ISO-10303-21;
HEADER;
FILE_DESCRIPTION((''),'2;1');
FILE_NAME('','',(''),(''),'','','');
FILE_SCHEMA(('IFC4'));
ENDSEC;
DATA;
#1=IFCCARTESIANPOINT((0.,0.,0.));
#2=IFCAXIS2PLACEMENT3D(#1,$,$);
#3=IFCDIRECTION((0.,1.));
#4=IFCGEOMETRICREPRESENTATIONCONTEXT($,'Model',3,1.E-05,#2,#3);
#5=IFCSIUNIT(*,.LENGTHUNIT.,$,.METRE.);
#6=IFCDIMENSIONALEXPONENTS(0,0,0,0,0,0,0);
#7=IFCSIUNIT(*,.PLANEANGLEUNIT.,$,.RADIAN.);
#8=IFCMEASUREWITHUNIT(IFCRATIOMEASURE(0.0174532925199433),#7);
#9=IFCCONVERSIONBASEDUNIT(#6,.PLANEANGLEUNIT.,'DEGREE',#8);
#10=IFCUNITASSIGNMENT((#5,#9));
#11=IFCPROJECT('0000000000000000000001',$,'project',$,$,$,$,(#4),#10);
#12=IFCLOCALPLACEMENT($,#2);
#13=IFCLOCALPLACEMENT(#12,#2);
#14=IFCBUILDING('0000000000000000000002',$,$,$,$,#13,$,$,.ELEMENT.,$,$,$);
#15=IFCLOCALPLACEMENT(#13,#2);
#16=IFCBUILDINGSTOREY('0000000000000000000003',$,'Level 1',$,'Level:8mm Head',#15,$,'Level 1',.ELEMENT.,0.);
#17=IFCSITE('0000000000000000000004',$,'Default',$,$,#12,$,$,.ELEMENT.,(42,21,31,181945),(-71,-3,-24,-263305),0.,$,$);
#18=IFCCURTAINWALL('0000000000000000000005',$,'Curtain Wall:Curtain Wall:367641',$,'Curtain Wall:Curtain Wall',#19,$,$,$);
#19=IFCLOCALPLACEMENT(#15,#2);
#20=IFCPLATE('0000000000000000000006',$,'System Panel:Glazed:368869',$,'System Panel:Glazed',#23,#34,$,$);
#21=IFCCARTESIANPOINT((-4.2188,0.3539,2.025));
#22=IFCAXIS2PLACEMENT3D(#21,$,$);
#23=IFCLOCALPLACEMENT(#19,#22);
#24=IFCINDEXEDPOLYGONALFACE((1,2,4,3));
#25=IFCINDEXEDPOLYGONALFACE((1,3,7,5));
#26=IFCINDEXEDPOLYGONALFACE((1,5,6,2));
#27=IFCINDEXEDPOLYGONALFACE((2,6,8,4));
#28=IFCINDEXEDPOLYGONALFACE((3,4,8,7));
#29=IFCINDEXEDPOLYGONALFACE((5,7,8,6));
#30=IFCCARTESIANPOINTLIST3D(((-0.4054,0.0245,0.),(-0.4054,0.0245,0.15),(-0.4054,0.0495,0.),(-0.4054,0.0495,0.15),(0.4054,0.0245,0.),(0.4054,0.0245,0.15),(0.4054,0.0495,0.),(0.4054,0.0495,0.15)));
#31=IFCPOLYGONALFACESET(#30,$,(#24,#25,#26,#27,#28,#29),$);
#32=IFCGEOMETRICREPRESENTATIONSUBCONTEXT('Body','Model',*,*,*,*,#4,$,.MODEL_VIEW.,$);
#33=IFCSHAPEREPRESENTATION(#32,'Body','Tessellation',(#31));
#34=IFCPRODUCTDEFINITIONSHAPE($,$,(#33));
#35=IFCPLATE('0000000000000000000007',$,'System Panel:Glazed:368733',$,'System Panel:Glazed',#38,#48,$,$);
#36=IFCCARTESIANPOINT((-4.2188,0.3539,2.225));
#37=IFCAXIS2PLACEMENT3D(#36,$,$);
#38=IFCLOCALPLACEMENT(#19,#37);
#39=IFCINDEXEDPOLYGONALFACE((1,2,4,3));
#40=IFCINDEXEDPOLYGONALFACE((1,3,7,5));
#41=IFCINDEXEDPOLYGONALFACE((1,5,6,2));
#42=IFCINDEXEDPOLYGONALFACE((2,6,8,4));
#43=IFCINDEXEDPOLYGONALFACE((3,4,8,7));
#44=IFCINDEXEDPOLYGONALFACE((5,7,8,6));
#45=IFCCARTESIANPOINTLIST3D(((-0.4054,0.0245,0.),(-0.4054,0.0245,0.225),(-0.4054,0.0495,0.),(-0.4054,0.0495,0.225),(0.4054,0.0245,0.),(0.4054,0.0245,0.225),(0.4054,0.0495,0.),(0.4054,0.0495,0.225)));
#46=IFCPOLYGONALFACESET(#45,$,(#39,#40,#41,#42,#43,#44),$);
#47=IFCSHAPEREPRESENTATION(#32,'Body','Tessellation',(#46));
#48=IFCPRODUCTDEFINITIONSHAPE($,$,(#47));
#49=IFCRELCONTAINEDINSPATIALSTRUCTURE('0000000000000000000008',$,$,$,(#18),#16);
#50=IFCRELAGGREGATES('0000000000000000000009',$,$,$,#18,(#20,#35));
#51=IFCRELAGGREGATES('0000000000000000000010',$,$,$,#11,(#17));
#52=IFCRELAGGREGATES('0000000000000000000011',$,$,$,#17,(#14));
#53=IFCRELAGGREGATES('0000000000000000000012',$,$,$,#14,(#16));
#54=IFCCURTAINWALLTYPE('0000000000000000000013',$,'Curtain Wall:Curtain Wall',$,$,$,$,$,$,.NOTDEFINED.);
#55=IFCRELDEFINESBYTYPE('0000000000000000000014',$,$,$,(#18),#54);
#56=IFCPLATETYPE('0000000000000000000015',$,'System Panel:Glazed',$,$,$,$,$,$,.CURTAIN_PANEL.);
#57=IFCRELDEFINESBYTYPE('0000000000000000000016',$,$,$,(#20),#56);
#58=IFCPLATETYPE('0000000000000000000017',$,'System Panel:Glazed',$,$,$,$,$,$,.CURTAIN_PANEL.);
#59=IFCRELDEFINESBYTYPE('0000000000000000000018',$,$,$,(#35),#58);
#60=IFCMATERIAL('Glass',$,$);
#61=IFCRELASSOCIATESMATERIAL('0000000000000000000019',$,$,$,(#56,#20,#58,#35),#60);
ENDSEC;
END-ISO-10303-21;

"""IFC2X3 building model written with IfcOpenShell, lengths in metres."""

from ifc_helpers import new_model, entity, si_unit, converted_unit, direction, frame, origin, origin_2d_with_axis, place, context, subcontext, project, spatial, rectangle, extrude, source, transform, mapped, material, type_object, type_shapes, element, aggregate, save


model = new_model("IFC2X3")

# Units and contexts
model_context = context("Model", 3, precision=1e-05, world=origin(), true_north=direction((0.0, 1.0)))
body_context = subcontext(model_context, "Body", "Model", "MODEL_VIEW")
ifc_project = project(units=[si_unit("LENGTHUNIT", "METRE"), converted_unit("PLANEANGLEUNIT", "DEGREE", entity("IfcRatioMeasure", 0.0174532925199433), si_unit("PLANEANGLEUNIT", "RADIAN"), dimensions=[0, 0, 0, 0, 0, 0, 0])], contexts=[model_context])

# Site, building, storey
site_placement = place(None, origin())
site = spatial("IfcSite", under=ifc_project, at=site_placement, Name="Default", CompositionType="ELEMENT", RefLatitude=(42, 21, 31, 181945), RefLongitude=(-71, -3, -24, -263305), RefElevation=0.0)
building_placement = place(site_placement, origin())
building = spatial("IfcBuilding", under=site, at=building_placement, CompositionType="ELEMENT")
storey_placement = place(building_placement, origin())
storey = spatial("IfcBuildingStorey", under=building, at=storey_placement, Name="Level 1", ObjectType="Level:8mm Head", LongName="Level 1", CompositionType="ELEMENT", Elevation=0.0)

# Curtain wall, plates
curtain_wall_type = type_object("IfcCurtainWallType", Name="Curtain Wall:Curtain Wall", PredefinedType="NOTDEFINED")
curtain_wall_placement = place(storey_placement, origin())
curtain_wall = element("IfcCurtainWall", 1, at=curtain_wall_placement, inside=storey, type_object=curtain_wall_type, Name="Curtain Wall:Curtain Wall:367641", ObjectType="Curtain Wall:Curtain Wall")
ifc_material_1 = material(Name="Glass")
plate_type_1 = type_object("IfcPlateType", Name="System Panel:Glazed", PredefinedType="CURTAIN_PANEL", material=ifc_material_1)
shared_shape_1 = source(origin(), body_context, "Body", "SweptSolid", [
    extrude(rectangle(XDim=0.025, YDim=0.8107, at=origin_2d_with_axis()), frame((0.0, 0.037, 0.0), z_axis=(0.0, 0.0, 1.0), x_axis=(0.0, 1.0, 0.0)), (0.0, 0.0, 1.0), 0.15),
])
type_shapes(plate_type_1, [shared_shape_1])
plate_1_placement = place(curtain_wall_placement, frame((-4.2188, 0.3539, 2.025)))
plate_1 = element("IfcPlate", 2, at=plate_1_placement, type_object=plate_type_1, material=ifc_material_1, Name="System Panel:Glazed:368869", ObjectType="System Panel:Glazed", context=body_context, shape_type="MappedRepresentation", body=[
    mapped(shared_shape_1, transform((0.0, 0.0, 0.0), scale=1.0)),
])
plate_type_2 = type_object("IfcPlateType", Name="System Panel:Glazed", PredefinedType="CURTAIN_PANEL", material=ifc_material_1)
shared_shape_2 = source(origin(), body_context, "Body", "SweptSolid", [
    extrude(rectangle(XDim=0.025, YDim=0.8107, at=origin_2d_with_axis()), frame((0.0, 0.037, 0.0), z_axis=(0.0, 0.0, 1.0), x_axis=(0.0, 1.0, 0.0)), (0.0, 0.0, 1.0), 0.225),
])
type_shapes(plate_type_2, [shared_shape_2])
plate_2_placement = place(curtain_wall_placement, frame((-4.2188, 0.3539, 2.225)))
plate_2 = element("IfcPlate", 3, at=plate_2_placement, type_object=plate_type_2, material=ifc_material_1, Name="System Panel:Glazed:368733", ObjectType="System Panel:Glazed", context=body_context, shape_type="MappedRepresentation", body=[
    mapped(shared_shape_2, transform((0.0, 0.0, 0.0), scale=1.0)),
])
aggregate(curtain_wall, [plate_1, plate_2])

save(model, "model.ifc")
